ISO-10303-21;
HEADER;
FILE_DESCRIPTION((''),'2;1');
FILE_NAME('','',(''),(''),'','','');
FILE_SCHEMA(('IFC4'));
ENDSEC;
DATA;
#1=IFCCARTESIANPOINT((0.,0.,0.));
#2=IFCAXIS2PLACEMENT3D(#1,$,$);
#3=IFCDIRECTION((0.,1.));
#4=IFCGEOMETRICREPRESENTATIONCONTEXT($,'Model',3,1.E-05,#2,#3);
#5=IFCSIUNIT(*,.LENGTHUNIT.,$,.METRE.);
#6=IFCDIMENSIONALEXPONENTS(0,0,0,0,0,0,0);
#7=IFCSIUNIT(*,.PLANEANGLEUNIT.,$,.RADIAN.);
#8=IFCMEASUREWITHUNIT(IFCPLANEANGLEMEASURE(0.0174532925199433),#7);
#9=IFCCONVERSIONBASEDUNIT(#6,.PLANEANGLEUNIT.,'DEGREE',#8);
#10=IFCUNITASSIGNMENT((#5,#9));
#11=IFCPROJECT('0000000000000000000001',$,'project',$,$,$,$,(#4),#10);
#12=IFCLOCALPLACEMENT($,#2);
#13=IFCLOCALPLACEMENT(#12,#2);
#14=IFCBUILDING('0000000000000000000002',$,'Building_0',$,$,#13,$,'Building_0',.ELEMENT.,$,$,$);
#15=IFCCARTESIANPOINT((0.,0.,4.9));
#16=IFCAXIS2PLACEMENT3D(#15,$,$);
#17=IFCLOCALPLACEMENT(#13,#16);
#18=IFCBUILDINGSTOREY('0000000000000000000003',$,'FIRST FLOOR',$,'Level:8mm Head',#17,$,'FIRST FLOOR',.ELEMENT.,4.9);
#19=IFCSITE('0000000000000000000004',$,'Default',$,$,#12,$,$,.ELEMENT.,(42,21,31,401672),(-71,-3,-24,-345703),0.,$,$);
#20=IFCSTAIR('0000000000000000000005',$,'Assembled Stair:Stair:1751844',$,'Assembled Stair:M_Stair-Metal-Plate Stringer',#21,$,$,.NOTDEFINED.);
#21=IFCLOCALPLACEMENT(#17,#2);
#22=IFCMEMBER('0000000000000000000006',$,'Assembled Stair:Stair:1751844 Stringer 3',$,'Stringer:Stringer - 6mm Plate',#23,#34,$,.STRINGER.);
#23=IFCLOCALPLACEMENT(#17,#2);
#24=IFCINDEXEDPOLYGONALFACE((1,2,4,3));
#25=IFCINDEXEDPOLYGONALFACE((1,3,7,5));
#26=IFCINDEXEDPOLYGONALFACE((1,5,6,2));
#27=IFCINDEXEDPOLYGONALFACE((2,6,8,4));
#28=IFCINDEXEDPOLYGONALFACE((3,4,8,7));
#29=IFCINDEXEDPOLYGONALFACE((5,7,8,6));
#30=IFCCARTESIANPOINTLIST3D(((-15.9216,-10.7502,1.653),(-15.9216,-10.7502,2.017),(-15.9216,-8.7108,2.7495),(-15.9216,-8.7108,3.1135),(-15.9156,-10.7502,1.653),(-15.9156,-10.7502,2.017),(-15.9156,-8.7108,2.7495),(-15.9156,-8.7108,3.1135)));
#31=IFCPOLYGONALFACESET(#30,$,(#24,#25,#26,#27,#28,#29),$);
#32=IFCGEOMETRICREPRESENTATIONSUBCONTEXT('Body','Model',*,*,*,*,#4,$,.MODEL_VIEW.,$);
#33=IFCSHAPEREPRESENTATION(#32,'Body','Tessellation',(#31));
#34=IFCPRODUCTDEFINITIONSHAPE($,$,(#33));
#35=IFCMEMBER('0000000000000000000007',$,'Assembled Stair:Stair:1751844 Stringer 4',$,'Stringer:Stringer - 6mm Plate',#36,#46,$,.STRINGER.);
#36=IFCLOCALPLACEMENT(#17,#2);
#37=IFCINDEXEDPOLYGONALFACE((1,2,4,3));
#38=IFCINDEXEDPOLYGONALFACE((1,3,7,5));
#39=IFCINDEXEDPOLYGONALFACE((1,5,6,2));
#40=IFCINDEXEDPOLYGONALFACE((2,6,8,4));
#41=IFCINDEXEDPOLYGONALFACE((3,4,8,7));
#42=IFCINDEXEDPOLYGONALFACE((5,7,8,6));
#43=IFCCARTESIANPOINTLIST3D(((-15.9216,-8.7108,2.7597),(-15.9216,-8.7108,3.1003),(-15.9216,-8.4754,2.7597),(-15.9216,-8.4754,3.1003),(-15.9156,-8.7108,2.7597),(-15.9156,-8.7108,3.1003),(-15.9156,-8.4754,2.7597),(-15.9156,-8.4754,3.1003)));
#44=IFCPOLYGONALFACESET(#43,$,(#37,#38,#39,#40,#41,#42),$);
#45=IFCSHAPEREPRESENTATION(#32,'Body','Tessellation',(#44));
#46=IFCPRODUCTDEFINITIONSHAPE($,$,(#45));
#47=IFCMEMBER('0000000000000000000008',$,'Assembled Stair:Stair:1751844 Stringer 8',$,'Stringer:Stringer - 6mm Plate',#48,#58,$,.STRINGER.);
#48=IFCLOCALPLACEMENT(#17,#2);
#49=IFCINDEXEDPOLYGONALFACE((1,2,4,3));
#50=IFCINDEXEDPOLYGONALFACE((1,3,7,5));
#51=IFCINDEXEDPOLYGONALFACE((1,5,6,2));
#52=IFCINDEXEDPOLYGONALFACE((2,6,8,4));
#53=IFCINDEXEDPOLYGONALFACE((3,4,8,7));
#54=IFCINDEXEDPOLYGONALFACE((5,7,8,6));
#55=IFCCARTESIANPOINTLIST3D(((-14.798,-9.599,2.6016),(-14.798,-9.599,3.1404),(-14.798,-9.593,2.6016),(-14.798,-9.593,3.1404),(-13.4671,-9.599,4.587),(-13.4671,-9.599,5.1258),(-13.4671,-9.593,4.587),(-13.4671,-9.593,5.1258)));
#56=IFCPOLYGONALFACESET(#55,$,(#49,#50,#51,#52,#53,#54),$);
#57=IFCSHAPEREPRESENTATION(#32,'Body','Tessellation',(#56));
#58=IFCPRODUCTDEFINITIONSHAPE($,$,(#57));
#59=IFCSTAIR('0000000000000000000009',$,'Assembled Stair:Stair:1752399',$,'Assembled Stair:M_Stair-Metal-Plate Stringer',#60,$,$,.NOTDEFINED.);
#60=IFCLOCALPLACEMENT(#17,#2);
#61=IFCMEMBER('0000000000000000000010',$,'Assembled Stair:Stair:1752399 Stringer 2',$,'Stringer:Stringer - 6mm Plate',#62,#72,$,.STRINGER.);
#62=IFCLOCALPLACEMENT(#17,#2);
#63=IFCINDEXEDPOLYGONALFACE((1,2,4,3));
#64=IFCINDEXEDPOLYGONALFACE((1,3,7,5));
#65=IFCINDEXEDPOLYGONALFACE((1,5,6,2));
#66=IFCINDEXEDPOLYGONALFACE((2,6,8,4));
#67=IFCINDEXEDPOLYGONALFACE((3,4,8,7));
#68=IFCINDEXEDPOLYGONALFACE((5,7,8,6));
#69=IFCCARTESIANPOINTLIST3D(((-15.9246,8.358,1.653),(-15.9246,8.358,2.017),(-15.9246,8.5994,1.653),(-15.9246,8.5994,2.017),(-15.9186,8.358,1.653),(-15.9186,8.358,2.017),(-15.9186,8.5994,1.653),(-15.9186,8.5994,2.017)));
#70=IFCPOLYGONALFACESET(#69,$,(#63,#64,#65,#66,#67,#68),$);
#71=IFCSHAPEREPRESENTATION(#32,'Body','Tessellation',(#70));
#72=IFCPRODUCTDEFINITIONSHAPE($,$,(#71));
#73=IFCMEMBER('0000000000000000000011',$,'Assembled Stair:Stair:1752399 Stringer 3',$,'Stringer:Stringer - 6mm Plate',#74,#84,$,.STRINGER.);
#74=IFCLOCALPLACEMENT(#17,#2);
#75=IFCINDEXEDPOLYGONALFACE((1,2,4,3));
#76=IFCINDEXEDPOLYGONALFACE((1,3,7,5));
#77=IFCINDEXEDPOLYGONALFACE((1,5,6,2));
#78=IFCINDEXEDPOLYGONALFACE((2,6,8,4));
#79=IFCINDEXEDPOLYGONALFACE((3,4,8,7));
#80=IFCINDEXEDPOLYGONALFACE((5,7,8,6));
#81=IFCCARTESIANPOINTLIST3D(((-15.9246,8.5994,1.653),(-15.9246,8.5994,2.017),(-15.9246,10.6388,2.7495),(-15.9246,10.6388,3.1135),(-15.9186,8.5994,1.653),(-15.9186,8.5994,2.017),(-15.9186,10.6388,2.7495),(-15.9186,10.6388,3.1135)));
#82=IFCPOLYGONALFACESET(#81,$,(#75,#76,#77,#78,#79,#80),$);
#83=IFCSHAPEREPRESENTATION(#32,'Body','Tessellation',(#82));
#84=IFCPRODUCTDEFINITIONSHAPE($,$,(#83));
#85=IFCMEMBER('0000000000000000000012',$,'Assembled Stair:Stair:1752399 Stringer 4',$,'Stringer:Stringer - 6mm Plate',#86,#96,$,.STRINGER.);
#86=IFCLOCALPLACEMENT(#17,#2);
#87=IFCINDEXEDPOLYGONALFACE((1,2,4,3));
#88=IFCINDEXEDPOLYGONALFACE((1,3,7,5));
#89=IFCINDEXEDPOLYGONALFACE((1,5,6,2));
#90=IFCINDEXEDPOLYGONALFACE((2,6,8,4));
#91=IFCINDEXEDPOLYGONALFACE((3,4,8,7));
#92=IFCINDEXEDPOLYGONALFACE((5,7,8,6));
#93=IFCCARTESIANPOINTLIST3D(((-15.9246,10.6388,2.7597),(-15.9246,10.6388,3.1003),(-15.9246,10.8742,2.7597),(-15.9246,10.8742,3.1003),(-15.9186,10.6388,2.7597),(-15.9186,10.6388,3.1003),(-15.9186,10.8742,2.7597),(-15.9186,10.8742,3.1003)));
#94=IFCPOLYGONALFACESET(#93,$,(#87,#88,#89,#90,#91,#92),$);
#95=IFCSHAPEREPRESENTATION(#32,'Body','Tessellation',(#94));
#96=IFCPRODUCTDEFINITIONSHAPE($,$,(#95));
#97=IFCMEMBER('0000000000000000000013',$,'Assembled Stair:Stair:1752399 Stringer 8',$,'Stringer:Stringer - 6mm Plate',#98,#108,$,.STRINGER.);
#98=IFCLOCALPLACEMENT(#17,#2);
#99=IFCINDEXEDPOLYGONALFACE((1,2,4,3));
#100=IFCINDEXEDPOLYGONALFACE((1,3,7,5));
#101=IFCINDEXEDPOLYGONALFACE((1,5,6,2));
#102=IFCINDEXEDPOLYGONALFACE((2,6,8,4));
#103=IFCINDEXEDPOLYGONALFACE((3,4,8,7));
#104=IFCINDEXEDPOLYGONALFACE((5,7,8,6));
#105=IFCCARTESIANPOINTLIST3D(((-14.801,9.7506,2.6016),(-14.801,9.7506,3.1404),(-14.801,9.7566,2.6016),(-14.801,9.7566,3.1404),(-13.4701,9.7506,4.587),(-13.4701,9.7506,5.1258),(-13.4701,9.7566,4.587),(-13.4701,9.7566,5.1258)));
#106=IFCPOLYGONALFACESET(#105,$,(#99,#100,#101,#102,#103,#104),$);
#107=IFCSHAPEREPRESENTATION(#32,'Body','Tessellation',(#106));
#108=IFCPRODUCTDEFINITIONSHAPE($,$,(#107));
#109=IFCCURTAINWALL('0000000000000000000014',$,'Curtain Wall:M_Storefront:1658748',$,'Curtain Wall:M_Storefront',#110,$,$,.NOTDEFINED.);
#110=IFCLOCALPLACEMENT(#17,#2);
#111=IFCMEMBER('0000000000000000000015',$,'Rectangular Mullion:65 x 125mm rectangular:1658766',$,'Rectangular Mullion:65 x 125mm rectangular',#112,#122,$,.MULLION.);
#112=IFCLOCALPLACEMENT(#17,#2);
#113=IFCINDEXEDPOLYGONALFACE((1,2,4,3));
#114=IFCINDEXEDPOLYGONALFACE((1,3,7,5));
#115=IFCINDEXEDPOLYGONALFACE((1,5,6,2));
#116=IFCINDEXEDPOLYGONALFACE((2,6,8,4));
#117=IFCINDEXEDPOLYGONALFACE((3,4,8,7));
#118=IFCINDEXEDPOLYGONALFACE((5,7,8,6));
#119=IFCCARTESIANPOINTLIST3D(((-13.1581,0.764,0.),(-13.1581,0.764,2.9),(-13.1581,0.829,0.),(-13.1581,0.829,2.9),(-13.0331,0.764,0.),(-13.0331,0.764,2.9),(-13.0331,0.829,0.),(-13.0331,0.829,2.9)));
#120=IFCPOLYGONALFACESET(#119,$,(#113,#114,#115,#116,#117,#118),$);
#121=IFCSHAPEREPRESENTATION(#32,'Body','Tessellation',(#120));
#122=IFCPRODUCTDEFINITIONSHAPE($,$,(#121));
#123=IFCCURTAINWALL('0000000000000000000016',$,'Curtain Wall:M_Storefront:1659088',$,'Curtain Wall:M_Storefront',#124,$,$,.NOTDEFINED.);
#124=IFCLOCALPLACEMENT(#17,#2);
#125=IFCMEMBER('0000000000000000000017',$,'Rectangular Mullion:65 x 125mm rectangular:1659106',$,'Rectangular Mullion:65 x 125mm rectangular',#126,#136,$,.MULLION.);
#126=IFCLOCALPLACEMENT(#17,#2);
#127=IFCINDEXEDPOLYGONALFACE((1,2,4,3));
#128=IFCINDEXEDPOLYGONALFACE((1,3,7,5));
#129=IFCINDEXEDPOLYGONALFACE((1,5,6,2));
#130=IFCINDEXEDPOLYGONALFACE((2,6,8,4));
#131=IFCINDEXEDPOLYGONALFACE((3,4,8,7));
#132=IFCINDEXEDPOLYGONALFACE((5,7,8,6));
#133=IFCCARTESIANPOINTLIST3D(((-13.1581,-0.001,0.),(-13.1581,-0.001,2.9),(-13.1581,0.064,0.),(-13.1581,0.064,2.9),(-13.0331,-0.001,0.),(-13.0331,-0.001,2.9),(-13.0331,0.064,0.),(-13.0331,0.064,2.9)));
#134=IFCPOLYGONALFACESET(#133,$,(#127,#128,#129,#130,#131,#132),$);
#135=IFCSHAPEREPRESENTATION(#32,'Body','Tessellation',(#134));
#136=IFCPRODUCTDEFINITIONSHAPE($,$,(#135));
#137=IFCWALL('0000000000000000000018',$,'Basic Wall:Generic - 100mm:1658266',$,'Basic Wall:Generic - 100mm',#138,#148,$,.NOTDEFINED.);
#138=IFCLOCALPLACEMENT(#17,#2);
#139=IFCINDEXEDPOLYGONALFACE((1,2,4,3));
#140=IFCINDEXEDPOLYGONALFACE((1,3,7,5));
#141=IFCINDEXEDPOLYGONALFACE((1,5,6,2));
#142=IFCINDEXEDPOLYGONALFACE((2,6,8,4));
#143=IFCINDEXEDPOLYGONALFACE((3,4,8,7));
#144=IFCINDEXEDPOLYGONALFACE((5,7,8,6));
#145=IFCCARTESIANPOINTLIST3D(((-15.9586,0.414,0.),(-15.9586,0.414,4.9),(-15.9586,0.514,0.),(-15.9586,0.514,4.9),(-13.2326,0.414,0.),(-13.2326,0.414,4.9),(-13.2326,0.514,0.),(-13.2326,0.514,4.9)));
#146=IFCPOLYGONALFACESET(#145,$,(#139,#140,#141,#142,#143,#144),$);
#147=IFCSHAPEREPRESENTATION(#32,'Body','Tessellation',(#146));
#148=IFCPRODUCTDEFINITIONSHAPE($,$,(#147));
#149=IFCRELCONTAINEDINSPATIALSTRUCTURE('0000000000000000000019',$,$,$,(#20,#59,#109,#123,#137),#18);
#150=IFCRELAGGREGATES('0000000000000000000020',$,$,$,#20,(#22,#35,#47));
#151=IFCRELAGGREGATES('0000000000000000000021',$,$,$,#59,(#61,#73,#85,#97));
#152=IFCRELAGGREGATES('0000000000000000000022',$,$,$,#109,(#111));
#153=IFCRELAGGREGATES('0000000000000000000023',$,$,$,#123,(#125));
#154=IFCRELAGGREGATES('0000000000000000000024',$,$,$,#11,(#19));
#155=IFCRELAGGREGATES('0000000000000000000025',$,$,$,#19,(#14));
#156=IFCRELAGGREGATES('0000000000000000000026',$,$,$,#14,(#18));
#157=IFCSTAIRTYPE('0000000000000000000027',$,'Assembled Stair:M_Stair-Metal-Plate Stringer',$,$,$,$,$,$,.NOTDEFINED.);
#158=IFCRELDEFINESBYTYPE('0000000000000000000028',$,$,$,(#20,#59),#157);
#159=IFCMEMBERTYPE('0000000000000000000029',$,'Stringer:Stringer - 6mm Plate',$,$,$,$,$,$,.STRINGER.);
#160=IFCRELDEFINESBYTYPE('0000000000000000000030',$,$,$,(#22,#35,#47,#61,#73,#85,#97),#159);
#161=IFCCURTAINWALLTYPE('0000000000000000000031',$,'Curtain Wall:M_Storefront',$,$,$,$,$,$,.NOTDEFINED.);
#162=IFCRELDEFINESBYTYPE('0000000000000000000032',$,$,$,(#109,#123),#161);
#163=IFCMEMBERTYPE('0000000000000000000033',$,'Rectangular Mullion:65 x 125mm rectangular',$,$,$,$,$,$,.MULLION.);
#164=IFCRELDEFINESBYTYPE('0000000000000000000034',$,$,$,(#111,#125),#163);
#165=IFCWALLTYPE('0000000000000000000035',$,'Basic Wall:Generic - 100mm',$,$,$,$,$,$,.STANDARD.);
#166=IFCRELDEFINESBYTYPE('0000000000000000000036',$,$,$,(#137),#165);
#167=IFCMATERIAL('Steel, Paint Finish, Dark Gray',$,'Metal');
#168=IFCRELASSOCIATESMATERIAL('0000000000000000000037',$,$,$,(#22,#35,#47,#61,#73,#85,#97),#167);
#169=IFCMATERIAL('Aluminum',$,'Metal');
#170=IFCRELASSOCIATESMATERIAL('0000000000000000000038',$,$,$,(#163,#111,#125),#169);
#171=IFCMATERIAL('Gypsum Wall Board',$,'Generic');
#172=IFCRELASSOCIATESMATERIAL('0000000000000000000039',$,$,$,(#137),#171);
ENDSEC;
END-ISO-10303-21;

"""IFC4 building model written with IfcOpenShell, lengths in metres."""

from ifc_helpers import new_model, entity, si_unit, converted_unit, direction, frame, origin, place, context, subcontext, project, spatial, indexed_curve, outline, extrude, source, transform, mapped, material, type_object, type_shapes, element, aggregate, save


model = new_model("IFC4")

# Units and contexts
model_context = context("Model", 3, precision=1e-05, world=origin(), true_north=direction((0.0, 1.0)))
body_context = subcontext(model_context, "Body", "Model", "MODEL_VIEW")
ifc_project = project(units=[si_unit("LENGTHUNIT", "METRE"), converted_unit("PLANEANGLEUNIT", "DEGREE", entity("IfcPlaneAngleMeasure", 0.0174532925199433), si_unit("PLANEANGLEUNIT", "RADIAN"), dimensions=[0, 0, 0, 0, 0, 0, 0])], contexts=[model_context])

# Site, building, storey
site_placement = place(None, origin())
site = spatial("IfcSite", under=ifc_project, at=site_placement, Name="Default", CompositionType="ELEMENT", RefLatitude=(42, 21, 31, 401672), RefLongitude=(-71, -3, -24, -345703), RefElevation=0.0)
building_placement = place(site_placement, origin())
building = spatial("IfcBuilding", under=site, at=building_placement, Name="Building_0", LongName="Building_0", CompositionType="ELEMENT")
storey_placement = place(building_placement, frame((0.0, 0.0, 4.9)))
storey = spatial("IfcBuildingStorey", under=building, at=storey_placement, Name="FIRST FLOOR", ObjectType="Level:8mm Head", LongName="FIRST FLOOR", CompositionType="ELEMENT", Elevation=4.9)

# Stairs, members
stair_type = type_object("IfcStairType", Name="Assembled Stair:M_Stair-Metal-Plate Stringer", PredefinedType="NOTDEFINED")
stair_1_placement = place(storey_placement, origin())
stair_1 = element("IfcStair", 1, at=stair_1_placement, inside=storey, type_object=stair_type, Name="Assembled Stair:Stair:1751844", ObjectType="Assembled Stair:M_Stair-Metal-Plate Stringer", PredefinedType="NOTDEFINED")
ifc_material_1 = material(Name="Steel, Paint Finish, Dark Gray", Category="Metal")
member_type_1 = type_object("IfcMemberType", Name="Stringer:Stringer - 6mm Plate", PredefinedType="STRINGER")
member_1_placement = place(stair_1_placement, origin())
member_1 = element("IfcMember", 2, at=member_1_placement, type_object=member_type_1, material=ifc_material_1, Name="Assembled Stair:Stair:1751844 Stringer 3", ObjectType="Stringer:Stringer - 6mm Plate", PredefinedType="STRINGER", context=body_context, shape_type="SweptSolid", body=[
    extrude(outline(indexed_curve([(-1.2439, -0.1603), (1.0716, -0.1603), (1.2439, 0.1603), (-1.0716, 0.1603), (-1.2439, -0.1603)], self_intersect=False)), frame((-15.9216, -9.7305, 2.3833), z_axis=(1.0, 0.0, 0.0), x_axis=(0.0, 0.880753, 0.473576)), (0.0, 0.0, 1.0), 0.006),
])
member_2_placement = place(stair_1_placement, origin())
member_2 = element("IfcMember", 3, at=member_2_placement, type_object=member_type_1, material=ifc_material_1, Name="Assembled Stair:Stair:1751844 Stringer 4", ObjectType="Stringer:Stringer - 6mm Plate", PredefinedType="STRINGER", context=body_context, shape_type="SweptSolid", body=[
    extrude(outline(indexed_curve([(-0.1177, -0.003), (0.1177, -0.003), (0.1177, 0.003), (-0.1177, 0.003), (-0.1177, -0.003)], self_intersect=False)), frame((-15.9186, -8.5931, 2.7597), z_axis=(0.0, 0.0, 1.0), x_axis=(0.0, 1.0, 0.0)), (0.0, 0.0, 1.0), 0.3406),
])
member_3_placement = place(stair_1_placement, origin())
member_3 = element("IfcMember", 4, at=member_3_placement, type_object=member_type_1, material=ifc_material_1, Name="Assembled Stair:Stair:1751844 Stringer 8", ObjectType="Stringer:Stringer - 6mm Plate", PredefinedType="STRINGER", context=body_context, shape_type="SweptSolid", body=[
    extrude(outline(indexed_curve([(-0.9713, -0.15), (1.4188, -0.15), (0.9713, 0.15), (-1.4188, 0.15), (-0.9713, -0.15)], self_intersect=False)), frame((-14.1326, -9.599, 3.8637), z_axis=(0.0, 1.0, 0.0), x_axis=(0.556804, 0.0, 0.830644)), (0.0, 0.0, 1.0), 0.006),
])
aggregate(stair_1, [member_1, member_2, member_3])
stair_2_placement = place(storey_placement, origin())
stair_2 = element("IfcStair", 5, at=stair_2_placement, inside=storey, type_object=stair_type, Name="Assembled Stair:Stair:1752399", ObjectType="Assembled Stair:M_Stair-Metal-Plate Stringer", PredefinedType="NOTDEFINED")
member_4_placement = place(stair_2_placement, origin())
member_4 = element("IfcMember", 6, at=member_4_placement, type_object=member_type_1, material=ifc_material_1, Name="Assembled Stair:Stair:1752399 Stringer 2", ObjectType="Stringer:Stringer - 6mm Plate", PredefinedType="STRINGER", context=body_context, shape_type="SweptSolid", body=[
    extrude(outline(indexed_curve([(-0.1207, -0.003), (0.1207, -0.003), (0.1207, 0.003), (-0.1207, 0.003), (-0.1207, -0.003)], self_intersect=False)), frame((-15.9216, 8.4787, 1.653), z_axis=(0.0, 0.0, 1.0), x_axis=(0.0, 1.0, 0.0)), (0.0, 0.0, 1.0), 0.364),
])
member_5_placement = place(stair_2_placement, origin())
member_5 = element("IfcMember", 7, at=member_5_placement, type_object=member_type_1, material=ifc_material_1, Name="Assembled Stair:Stair:1752399 Stringer 3", ObjectType="Stringer:Stringer - 6mm Plate", PredefinedType="STRINGER", context=body_context, shape_type="SweptSolid", body=[
    extrude(outline(indexed_curve([(-1.2439, -0.1603), (1.0716, -0.1603), (1.2439, 0.1603), (-1.0716, 0.1603), (-1.2439, -0.1603)], self_intersect=False)), frame((-15.9246, 9.6191, 2.3833), z_axis=(1.0, 0.0, 0.0), x_axis=(0.0, 0.880753, 0.473576)), (0.0, 0.0, 1.0), 0.006),
])
member_6_placement = place(stair_2_placement, origin())
member_6 = element("IfcMember", 8, at=member_6_placement, type_object=member_type_1, material=ifc_material_1, Name="Assembled Stair:Stair:1752399 Stringer 4", ObjectType="Stringer:Stringer - 6mm Plate", PredefinedType="STRINGER", context=body_context, shape_type="SweptSolid", body=[
    extrude(outline(indexed_curve([(-0.1177, -0.003), (0.1177, -0.003), (0.1177, 0.003), (-0.1177, 0.003), (-0.1177, -0.003)], self_intersect=False)), frame((-15.9216, 10.7565, 2.7597), z_axis=(0.0, 0.0, 1.0), x_axis=(0.0, 1.0, 0.0)), (0.0, 0.0, 1.0), 0.3406),
])
member_7_placement = place(stair_2_placement, origin())
member_7 = element("IfcMember", 9, at=member_7_placement, type_object=member_type_1, material=ifc_material_1, Name="Assembled Stair:Stair:1752399 Stringer 8", ObjectType="Stringer:Stringer - 6mm Plate", PredefinedType="STRINGER", context=body_context, shape_type="SweptSolid", body=[
    extrude(outline(indexed_curve([(-0.9713, -0.15), (1.4188, -0.15), (0.9713, 0.15), (-1.4188, 0.15), (-0.9713, -0.15)], self_intersect=False)), frame((-14.1356, 9.7506, 3.8637), z_axis=(0.0, 1.0, 0.0), x_axis=(0.556804, 0.0, 0.830644)), (0.0, 0.0, 1.0), 0.006),
])
aggregate(stair_2, [member_4, member_5, member_6, member_7])

# Curtain walls, members
curtain_wall_type = type_object("IfcCurtainWallType", Name="Curtain Wall:M_Storefront", PredefinedType="NOTDEFINED")
curtain_wall_1_placement = place(storey_placement, frame((0.0, 0.0, -4.9)))
curtain_wall_1 = element("IfcCurtainWall", 10, at=curtain_wall_1_placement, inside=storey, type_object=curtain_wall_type, Name="Curtain Wall:M_Storefront:1658748", ObjectType="Curtain Wall:M_Storefront", PredefinedType="NOTDEFINED")
ifc_material_2 = material(Name="Aluminum", Category="Metal")
member_type_2 = type_object("IfcMemberType", Name="Rectangular Mullion:65 x 125mm rectangular", PredefinedType="MULLION", material=ifc_material_2)
shared_shape_1 = source(origin(), body_context, "Body", "SweptSolid", [
    extrude(outline(indexed_curve([(-0.0325, -0.0625), (0.0325, -0.0625), (0.0325, 0.0625), (-0.0325, 0.0625), (-0.0325, -0.0625)], self_intersect=False)), frame((-0.0325, 0.0, -2.9), z_axis=(0.0, 0.0, 1.0), x_axis=(-1.0, 0.0, 0.0)), (0.0, 0.0, 1.0), 2.9),
])
type_shapes(member_type_2, [shared_shape_1])
member_8_placement = place(curtain_wall_1_placement, frame((-13.0956, 0.764, 4.9), z_axis=(0.0, 0.0, -1.0), x_axis=(0.0, -1.0, 0.0)))
member_8 = element("IfcMember", 11, at=member_8_placement, type_object=member_type_2, material=ifc_material_2, Name="Rectangular Mullion:65 x 125mm rectangular:1658766", ObjectType="Rectangular Mullion:65 x 125mm rectangular", PredefinedType="MULLION", context=body_context, shape_type="MappedRepresentation", body=[
    mapped(shared_shape_1, transform((0.0, 0.0, 0.0), scale=1.0)),
])
aggregate(curtain_wall_1, [member_8])
curtain_wall_2_placement = place(storey_placement, frame((0.0, 0.0, -4.9)))
curtain_wall_2 = element("IfcCurtainWall", 12, at=curtain_wall_2_placement, inside=storey, type_object=curtain_wall_type, Name="Curtain Wall:M_Storefront:1659088", ObjectType="Curtain Wall:M_Storefront", PredefinedType="NOTDEFINED")
member_9_placement = place(curtain_wall_2_placement, frame((-13.0956, 0.064, 4.9), z_axis=(0.0, 0.0, -1.0), x_axis=(0.0, 1.0, 0.0)))
member_9 = element("IfcMember", 13, at=member_9_placement, type_object=member_type_2, material=ifc_material_2, Name="Rectangular Mullion:65 x 125mm rectangular:1659106", ObjectType="Rectangular Mullion:65 x 125mm rectangular", PredefinedType="MULLION", context=body_context, shape_type="MappedRepresentation", body=[
    mapped(shared_shape_1, transform((0.0, 0.0, 0.0), scale=1.0)),
])
aggregate(curtain_wall_2, [member_9])

# Wall
ifc_material_3 = material(Name="Gypsum Wall Board", Category="Generic")
wall_type = type_object("IfcWallType", Name="Basic Wall:Generic - 100mm", PredefinedType="STANDARD")
wall_placement = place(storey_placement, frame((-15.9586, 0.464, 0.0)))
element("IfcWall", 14, at=wall_placement, inside=storey, type_object=wall_type, material=ifc_material_3, Name="Basic Wall:Generic - 100mm:1658266", ObjectType="Basic Wall:Generic - 100mm", PredefinedType="NOTDEFINED", context=body_context, shape_type="SweptSolid", body=[
    extrude(outline(indexed_curve([(2.726, 0.05), (0.0, 0.05), (0.0, -0.05), (2.726, -0.05), (2.726, 0.05)], self_intersect=False)), origin(), (0.0, 0.0, 1.0), 4.9),
])

save(model, "model.ifc")
